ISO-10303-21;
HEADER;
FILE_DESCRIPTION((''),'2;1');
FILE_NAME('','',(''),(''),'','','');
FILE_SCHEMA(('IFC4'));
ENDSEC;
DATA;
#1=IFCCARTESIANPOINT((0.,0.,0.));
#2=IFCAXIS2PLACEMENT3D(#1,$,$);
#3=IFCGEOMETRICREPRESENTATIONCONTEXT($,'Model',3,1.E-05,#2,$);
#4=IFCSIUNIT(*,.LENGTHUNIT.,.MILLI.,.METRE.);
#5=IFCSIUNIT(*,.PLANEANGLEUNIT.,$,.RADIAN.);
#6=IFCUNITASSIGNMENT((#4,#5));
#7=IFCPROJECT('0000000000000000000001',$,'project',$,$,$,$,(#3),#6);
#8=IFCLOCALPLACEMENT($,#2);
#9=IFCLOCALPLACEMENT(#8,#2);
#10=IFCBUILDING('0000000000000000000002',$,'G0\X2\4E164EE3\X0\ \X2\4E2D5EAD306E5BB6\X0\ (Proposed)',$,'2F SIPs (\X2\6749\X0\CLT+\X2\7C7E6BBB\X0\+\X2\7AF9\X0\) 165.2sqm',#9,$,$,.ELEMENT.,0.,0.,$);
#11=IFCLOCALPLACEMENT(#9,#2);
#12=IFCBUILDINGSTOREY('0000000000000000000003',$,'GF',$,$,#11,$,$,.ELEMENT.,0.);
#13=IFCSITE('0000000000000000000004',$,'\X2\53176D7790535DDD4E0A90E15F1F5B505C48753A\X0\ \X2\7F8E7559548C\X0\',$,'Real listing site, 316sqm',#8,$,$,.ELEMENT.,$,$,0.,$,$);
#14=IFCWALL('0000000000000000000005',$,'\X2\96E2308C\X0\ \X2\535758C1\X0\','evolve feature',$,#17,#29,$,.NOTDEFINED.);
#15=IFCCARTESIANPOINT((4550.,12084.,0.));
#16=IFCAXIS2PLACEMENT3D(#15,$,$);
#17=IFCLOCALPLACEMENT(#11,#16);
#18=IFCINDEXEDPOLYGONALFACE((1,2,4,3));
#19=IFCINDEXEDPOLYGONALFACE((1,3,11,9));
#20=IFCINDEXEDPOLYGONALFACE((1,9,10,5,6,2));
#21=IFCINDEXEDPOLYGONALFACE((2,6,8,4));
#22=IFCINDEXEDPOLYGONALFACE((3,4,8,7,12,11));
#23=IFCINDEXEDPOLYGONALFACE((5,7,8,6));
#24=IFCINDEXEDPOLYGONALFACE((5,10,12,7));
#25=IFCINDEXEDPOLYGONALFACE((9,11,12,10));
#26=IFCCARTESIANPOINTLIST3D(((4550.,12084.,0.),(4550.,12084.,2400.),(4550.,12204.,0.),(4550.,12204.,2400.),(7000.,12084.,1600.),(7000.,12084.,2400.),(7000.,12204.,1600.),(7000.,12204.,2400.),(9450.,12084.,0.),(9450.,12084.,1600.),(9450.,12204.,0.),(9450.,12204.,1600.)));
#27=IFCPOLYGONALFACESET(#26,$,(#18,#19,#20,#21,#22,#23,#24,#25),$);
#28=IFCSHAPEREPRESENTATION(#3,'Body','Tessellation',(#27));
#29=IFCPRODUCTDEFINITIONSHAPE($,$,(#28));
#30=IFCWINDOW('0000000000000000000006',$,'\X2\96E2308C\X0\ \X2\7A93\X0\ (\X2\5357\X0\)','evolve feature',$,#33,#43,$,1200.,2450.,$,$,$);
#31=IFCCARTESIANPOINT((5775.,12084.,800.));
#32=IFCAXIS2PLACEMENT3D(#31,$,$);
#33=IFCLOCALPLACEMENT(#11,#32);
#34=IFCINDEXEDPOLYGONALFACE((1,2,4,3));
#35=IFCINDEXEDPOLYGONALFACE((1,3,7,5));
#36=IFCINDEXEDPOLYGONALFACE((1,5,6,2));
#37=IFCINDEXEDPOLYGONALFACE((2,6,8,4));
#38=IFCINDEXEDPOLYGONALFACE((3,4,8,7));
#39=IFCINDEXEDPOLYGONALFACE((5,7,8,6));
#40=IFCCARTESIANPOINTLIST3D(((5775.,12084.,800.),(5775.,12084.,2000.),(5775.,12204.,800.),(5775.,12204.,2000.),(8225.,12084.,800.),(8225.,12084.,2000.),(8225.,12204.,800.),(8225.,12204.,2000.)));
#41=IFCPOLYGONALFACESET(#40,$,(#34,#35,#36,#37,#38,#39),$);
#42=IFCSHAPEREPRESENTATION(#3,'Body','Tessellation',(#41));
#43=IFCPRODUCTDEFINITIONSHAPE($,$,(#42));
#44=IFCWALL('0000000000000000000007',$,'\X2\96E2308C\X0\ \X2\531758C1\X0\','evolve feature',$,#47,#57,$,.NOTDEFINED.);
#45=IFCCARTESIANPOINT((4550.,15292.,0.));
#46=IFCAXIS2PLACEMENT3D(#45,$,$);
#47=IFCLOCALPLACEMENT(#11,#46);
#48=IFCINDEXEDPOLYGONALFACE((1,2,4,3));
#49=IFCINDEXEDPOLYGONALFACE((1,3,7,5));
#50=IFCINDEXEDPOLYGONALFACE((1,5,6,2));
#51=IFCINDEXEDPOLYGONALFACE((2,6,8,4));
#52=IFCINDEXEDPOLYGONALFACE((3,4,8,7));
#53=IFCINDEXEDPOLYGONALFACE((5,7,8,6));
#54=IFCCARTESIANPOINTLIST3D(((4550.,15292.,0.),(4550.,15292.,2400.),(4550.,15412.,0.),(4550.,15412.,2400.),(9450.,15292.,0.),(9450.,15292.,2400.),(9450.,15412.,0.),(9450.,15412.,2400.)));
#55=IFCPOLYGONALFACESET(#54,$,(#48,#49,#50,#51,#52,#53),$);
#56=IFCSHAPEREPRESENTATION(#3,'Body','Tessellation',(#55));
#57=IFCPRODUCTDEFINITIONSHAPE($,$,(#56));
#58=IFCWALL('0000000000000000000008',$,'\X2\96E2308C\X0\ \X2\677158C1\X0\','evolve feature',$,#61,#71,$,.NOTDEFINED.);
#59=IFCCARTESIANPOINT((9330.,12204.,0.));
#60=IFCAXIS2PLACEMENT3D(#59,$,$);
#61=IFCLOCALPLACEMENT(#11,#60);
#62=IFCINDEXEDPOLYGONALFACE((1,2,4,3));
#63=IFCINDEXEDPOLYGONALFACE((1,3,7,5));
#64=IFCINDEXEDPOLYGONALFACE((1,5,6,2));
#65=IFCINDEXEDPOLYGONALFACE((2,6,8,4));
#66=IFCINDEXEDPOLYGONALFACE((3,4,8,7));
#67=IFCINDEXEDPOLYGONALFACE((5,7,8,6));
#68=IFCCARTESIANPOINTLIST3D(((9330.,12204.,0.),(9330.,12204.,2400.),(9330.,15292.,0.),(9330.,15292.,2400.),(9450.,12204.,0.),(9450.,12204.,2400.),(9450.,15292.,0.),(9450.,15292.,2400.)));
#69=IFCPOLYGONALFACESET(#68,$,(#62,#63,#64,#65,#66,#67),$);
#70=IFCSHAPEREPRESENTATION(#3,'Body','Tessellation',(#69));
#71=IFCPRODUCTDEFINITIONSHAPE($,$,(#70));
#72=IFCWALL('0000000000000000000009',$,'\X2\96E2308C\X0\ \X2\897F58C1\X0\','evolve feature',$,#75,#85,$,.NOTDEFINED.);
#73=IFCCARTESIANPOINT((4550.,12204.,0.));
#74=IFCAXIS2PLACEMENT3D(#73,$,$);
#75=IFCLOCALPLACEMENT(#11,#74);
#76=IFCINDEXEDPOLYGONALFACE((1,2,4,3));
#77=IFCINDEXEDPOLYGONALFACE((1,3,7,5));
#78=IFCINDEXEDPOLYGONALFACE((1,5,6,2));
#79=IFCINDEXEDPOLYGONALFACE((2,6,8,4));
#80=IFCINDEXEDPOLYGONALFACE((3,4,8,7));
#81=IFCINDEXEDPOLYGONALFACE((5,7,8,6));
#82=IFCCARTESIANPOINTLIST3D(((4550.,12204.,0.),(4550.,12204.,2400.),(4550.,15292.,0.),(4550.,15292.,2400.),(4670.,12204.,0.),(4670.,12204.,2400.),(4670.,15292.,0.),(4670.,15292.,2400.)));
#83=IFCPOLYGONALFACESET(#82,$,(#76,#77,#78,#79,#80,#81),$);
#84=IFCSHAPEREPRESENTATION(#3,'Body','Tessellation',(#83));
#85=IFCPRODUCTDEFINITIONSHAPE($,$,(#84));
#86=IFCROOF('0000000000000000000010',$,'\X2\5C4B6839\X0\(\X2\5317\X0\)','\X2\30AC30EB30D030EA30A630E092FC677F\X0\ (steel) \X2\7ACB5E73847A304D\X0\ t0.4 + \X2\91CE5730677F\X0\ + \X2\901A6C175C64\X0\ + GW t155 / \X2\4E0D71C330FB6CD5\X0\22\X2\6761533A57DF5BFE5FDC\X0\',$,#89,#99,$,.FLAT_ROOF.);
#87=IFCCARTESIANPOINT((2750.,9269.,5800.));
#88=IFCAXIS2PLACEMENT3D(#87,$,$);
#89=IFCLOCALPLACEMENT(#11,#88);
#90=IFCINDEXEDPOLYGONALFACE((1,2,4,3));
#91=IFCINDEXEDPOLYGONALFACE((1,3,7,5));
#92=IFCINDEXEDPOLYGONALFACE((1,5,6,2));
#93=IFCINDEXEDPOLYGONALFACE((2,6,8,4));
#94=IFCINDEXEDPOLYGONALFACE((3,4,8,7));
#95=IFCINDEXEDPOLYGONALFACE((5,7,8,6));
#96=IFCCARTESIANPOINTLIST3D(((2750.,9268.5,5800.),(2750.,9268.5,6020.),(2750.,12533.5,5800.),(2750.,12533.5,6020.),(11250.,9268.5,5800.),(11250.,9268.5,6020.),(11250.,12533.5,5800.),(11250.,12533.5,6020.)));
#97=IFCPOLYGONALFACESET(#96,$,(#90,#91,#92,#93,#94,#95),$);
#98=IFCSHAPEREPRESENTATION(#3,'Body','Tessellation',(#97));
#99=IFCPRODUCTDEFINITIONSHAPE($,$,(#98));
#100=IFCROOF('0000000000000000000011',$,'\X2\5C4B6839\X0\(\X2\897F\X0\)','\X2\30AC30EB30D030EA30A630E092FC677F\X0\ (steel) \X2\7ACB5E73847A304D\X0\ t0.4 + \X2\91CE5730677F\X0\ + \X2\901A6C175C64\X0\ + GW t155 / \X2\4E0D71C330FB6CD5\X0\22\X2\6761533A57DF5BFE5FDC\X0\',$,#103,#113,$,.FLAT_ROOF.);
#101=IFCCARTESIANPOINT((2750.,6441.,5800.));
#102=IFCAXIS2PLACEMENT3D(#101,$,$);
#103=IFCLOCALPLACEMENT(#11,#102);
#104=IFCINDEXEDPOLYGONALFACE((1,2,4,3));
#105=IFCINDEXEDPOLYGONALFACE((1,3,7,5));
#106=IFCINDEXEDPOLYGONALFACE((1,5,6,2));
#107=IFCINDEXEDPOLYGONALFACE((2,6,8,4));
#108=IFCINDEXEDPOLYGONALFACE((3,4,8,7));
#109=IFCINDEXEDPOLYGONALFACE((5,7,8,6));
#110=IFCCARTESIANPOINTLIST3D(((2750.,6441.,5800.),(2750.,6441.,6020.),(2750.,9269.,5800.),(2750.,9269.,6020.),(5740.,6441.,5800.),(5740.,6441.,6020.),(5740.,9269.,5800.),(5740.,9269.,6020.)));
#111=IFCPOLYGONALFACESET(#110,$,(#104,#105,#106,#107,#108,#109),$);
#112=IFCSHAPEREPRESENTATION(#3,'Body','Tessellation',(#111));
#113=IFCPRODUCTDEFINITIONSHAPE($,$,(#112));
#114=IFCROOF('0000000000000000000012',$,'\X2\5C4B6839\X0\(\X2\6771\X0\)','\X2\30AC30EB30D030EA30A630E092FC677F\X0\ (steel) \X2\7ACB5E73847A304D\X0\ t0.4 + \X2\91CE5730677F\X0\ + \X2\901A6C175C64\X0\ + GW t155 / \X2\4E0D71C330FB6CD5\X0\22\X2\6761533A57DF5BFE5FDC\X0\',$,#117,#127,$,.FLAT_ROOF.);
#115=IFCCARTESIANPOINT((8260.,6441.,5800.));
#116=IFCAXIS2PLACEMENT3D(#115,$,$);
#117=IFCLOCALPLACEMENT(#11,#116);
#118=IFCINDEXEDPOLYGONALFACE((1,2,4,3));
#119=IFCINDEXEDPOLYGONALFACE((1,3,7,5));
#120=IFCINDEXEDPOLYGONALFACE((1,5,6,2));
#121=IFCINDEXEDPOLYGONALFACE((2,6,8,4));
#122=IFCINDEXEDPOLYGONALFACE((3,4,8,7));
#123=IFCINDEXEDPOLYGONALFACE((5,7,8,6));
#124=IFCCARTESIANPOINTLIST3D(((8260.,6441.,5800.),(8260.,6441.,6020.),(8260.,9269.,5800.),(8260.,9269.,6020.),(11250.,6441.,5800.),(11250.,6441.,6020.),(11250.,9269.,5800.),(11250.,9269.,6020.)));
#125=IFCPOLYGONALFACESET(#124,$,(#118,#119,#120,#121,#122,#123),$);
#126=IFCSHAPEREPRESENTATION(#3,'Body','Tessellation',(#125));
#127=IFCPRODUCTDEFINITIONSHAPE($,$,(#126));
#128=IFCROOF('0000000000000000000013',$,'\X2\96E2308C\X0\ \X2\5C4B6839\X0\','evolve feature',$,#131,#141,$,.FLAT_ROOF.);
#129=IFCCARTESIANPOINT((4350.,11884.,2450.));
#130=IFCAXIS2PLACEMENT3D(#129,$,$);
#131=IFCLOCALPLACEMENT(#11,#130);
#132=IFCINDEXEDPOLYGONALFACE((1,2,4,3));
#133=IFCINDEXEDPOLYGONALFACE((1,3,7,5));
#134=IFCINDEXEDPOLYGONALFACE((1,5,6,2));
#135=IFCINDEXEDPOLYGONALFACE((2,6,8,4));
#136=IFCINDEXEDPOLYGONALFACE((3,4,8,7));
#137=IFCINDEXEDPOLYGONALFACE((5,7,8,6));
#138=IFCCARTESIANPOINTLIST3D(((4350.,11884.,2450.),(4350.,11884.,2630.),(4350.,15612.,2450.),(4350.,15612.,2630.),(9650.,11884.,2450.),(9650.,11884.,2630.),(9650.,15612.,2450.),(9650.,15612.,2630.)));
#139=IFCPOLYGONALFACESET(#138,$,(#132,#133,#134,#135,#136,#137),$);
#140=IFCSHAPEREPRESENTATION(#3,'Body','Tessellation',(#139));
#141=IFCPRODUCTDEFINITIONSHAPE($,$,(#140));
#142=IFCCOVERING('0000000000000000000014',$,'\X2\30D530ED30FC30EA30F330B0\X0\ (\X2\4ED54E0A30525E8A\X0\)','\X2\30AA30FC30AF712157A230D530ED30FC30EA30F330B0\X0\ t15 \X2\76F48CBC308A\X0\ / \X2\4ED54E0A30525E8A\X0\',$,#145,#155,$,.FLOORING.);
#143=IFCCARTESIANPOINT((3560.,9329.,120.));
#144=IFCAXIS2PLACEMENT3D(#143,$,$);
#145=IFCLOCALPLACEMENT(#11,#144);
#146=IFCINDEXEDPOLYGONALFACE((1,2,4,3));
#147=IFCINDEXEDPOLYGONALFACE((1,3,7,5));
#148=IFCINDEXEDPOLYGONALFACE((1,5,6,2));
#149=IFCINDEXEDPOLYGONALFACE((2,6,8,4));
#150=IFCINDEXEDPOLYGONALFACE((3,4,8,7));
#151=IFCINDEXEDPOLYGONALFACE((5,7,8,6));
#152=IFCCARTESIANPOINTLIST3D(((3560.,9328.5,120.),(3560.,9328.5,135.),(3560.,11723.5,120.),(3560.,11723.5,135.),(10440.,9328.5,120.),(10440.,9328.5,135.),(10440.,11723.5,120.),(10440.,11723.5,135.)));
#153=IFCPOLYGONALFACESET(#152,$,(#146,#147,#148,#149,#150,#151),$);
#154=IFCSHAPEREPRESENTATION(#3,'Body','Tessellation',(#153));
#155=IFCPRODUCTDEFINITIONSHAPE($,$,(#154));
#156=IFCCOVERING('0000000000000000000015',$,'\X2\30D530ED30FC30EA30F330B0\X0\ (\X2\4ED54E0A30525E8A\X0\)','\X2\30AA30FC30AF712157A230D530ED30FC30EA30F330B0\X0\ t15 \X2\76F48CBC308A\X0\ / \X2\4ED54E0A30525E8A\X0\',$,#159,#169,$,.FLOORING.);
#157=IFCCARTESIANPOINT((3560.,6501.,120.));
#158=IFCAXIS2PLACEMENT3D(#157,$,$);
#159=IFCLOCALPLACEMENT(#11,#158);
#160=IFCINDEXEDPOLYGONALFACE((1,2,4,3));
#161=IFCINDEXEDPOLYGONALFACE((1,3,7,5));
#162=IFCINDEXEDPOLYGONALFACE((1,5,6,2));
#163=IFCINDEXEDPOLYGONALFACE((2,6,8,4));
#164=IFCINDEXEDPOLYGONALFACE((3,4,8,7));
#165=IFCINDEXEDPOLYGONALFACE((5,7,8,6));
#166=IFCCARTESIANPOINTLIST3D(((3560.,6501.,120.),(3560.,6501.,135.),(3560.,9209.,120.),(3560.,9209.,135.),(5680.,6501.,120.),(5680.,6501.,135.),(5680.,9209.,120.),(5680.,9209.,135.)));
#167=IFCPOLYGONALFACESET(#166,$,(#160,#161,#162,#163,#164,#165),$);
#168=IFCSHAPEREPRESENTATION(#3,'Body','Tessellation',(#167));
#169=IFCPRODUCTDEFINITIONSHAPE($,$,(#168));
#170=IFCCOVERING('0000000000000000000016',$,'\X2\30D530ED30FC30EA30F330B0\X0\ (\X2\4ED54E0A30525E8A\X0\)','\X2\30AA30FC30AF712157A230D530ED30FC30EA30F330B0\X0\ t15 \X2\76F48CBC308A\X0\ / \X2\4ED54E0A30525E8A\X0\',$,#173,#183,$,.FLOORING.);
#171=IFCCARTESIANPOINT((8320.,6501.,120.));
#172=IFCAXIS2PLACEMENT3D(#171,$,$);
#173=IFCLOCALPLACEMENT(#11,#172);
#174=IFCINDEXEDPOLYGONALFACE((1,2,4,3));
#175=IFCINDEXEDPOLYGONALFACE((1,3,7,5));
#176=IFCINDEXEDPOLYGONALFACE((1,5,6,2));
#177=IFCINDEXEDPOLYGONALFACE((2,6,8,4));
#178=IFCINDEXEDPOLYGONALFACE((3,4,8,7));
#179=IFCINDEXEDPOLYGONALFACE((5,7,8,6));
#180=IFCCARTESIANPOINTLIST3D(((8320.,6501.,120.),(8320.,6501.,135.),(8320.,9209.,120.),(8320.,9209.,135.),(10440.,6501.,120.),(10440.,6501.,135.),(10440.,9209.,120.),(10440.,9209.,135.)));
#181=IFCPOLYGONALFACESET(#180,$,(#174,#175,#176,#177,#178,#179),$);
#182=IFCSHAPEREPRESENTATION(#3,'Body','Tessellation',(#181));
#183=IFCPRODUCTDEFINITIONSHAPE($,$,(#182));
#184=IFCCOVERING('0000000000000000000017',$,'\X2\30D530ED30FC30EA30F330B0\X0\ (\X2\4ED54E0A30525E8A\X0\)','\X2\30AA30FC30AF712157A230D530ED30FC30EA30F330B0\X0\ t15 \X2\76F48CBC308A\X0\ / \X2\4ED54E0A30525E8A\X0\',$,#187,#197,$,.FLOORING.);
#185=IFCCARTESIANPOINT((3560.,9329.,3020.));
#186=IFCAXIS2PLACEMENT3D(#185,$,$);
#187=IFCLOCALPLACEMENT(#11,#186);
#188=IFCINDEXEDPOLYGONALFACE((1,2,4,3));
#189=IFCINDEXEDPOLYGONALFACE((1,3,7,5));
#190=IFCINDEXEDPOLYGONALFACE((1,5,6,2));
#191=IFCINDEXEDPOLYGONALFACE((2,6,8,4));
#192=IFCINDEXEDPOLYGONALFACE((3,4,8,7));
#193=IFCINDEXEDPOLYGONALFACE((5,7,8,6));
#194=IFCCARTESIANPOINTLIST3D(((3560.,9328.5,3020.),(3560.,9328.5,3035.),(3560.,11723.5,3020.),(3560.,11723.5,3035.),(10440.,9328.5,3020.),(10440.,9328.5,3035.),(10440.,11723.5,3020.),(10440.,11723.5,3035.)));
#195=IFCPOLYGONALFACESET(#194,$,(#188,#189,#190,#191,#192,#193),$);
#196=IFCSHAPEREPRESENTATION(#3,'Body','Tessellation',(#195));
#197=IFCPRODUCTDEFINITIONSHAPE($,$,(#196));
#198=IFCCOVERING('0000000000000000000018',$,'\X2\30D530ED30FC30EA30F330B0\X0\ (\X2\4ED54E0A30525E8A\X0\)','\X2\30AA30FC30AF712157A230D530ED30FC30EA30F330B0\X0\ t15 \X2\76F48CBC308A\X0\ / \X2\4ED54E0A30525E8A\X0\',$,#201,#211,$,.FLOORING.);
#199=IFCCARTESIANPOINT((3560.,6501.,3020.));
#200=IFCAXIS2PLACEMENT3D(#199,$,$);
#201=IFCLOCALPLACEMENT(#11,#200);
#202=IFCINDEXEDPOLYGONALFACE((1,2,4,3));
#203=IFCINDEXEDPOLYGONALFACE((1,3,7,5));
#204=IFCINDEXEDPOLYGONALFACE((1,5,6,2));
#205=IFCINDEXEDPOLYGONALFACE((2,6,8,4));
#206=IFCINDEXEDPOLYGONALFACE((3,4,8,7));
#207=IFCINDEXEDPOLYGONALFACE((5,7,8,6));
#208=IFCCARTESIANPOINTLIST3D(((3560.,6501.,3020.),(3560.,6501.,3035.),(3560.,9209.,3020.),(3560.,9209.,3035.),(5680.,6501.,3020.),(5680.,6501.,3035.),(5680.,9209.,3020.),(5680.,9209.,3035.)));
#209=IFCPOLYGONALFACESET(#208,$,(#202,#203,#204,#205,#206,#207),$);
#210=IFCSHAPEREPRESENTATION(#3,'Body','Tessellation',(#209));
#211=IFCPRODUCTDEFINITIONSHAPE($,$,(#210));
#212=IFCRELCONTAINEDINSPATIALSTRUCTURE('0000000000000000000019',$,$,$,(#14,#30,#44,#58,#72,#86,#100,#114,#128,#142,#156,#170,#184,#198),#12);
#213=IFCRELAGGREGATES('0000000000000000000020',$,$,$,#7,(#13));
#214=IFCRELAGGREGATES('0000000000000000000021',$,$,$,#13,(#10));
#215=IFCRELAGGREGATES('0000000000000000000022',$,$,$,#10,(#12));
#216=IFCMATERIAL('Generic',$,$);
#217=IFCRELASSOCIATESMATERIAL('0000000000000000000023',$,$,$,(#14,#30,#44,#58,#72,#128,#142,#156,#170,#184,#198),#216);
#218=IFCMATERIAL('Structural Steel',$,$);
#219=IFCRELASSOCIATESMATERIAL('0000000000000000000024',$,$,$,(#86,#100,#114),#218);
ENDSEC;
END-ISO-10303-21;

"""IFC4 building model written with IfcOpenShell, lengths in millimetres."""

from ifc_helpers import new_model, si_unit, frame, frame_2d, origin, place, context, project, spatial, rectangle, extrude, material, element, fill, save


model = new_model("IFC4")

# Units and contexts
model_context = context("Model", 3, precision=1e-05, world=origin())
ifc_project = project(units=[si_unit("LENGTHUNIT", "METRE", prefix="MILLI"), si_unit("PLANEANGLEUNIT", "RADIAN")], contexts=[model_context])

# Site, building, storey
site_placement = place(None, origin())
site = spatial("IfcSite", under=ifc_project, at=site_placement, Name="北海道川上郡弟子屈町 美留和", ObjectType="Real listing site, 316sqm", CompositionType="ELEMENT", RefElevation=0.0)
building_placement = place(site_placement, origin())
building = spatial("IfcBuilding", under=site, at=building_placement, Name="G0世代 中庭の家 (Proposed)", ObjectType="2F SIPs (杉CLT+籾殻+竹) 165.2sqm", CompositionType="ELEMENT", ElevationOfRefHeight=0.0, ElevationOfTerrain=0.0)
storey_placement = place(building_placement, origin())
storey = spatial("IfcBuildingStorey", under=building, at=storey_placement, Name="GF", CompositionType="ELEMENT", Elevation=0.0)

# Shared definitions
ifc_material_1 = material(Name="Generic")

# Wall, opening, window
wall_1_placement = place(storey_placement, frame((4550.0, 12084.0, 0.0)))
wall_1 = element("IfcWall", 1, at=wall_1_placement, inside=storey, material=ifc_material_1, Name="離れ 南壁", Description="evolve feature", PredefinedType="NOTDEFINED", context=model_context, shape_type="SweptSolid", body=[
    extrude(rectangle(XDim=4900.0, YDim=120.0, at=frame_2d((2450.0, 60.0))), frame((4550.0, 12084.0, 0.0)), (0.0, 0.0, 1.0), 2400.0),
])
opening_1_placement = place(storey_placement, frame((5775.0, 12084.0, 800.0)))
opening_1 = element("IfcOpeningElement", 2, at=opening_1_placement, cuts=wall_1, PredefinedType="NOTDEFINED", context=model_context, shape_type="SweptSolid", body=[
    extrude(rectangle(XDim=2450.0, YDim=120.0, at=frame_2d((1225.0, 60.0))), frame((5775.0, 12084.0, 800.0)), (0.0, 0.0, 1.0), 1200.0),
])
window_1_placement = place(storey_placement, frame((5775.0, 12084.0, 800.0)))
window_1 = element("IfcWindow", 3, at=window_1_placement, inside=storey, material=ifc_material_1, Name="離れ 窓 (南)", Description="evolve feature", OverallHeight=1200.0, OverallWidth=2450.0, context=model_context, shape_type="SweptSolid", body=[
    extrude(rectangle(XDim=2450.0, YDim=120.0, at=frame_2d((1225.0, 60.0))), frame((5775.0, 12084.0, 800.0)), (0.0, 0.0, 1.0), 1200.0),
])
fill(opening_1, window_1)

# Walls
wall_2_placement = place(storey_placement, frame((4550.0, 15292.0, 0.0)))
element("IfcWall", 4, at=wall_2_placement, inside=storey, material=ifc_material_1, Name="離れ 北壁", Description="evolve feature", PredefinedType="NOTDEFINED", context=model_context, shape_type="SweptSolid", body=[
    extrude(rectangle(XDim=4900.0, YDim=120.0, at=frame_2d((2450.0, 60.0))), frame((4550.0, 15292.0, 0.0)), (0.0, 0.0, 1.0), 2400.0),
])
wall_3_placement = place(storey_placement, frame((9330.0, 12204.0, 0.0)))
element("IfcWall", 5, at=wall_3_placement, inside=storey, material=ifc_material_1, Name="離れ 東壁", Description="evolve feature", PredefinedType="NOTDEFINED", context=model_context, shape_type="SweptSolid", body=[
    extrude(rectangle(XDim=120.0, YDim=3088.0, at=frame_2d((60.0, 1544.0))), frame((9330.0, 12204.0, 0.0)), (0.0, 0.0, 1.0), 2400.0),
])
wall_4_placement = place(storey_placement, frame((4550.0, 12204.0, 0.0)))
element("IfcWall", 6, at=wall_4_placement, inside=storey, material=ifc_material_1, Name="離れ 西壁", Description="evolve feature", PredefinedType="NOTDEFINED", context=model_context, shape_type="SweptSolid", body=[
    extrude(rectangle(XDim=120.0, YDim=3088.0, at=frame_2d((60.0, 1544.0))), frame((4550.0, 12204.0, 0.0)), (0.0, 0.0, 1.0), 2400.0),
])

# Roofs
ifc_material_2 = material(Name="Structural Steel")
for number, where, name in (
    (7, (2750.0, 9269.0, 5800.0), "屋根(北)"),
):
    element("IfcRoof", number, at=place(storey_placement, frame(where)), inside=storey, material=ifc_material_2, Name=name, Description="ガルバリウム鋼板 (steel) 立平葺き t0.4 + 野地板 + 通気層 + GW t155 / 不燃・法22条区域対応", PredefinedType="FLAT_ROOF", context=model_context, shape_type="SweptSolid", body=[
        extrude(rectangle(XDim=8500.0, YDim=3265.0, at=frame_2d((4250.0, 1632.0))), frame((2750.0, 9269.0, 5800.0)), (0.0, 0.0, 1.0), 220.0),
    ])
roof_1_placement = place(storey_placement, frame((2750.0, 6441.0, 5800.0)))
element("IfcRoof", 8, at=roof_1_placement, inside=storey, material=ifc_material_2, Name="屋根(西)", Description="ガルバリウム鋼板 (steel) 立平葺き t0.4 + 野地板 + 通気層 + GW t155 / 不燃・法22条区域対応", PredefinedType="FLAT_ROOF", context=model_context, shape_type="SweptSolid", body=[
    extrude(rectangle(XDim=2990.0, YDim=2828.0, at=frame_2d((1495.0, 1414.0))), frame((2750.0, 6441.0, 5800.0)), (0.0, 0.0, 1.0), 220.0),
])
roof_2_placement = place(storey_placement, frame((8260.0, 6441.0, 5800.0)))
element("IfcRoof", 9, at=roof_2_placement, inside=storey, material=ifc_material_2, Name="屋根(東)", Description="ガルバリウム鋼板 (steel) 立平葺き t0.4 + 野地板 + 通気層 + GW t155 / 不燃・法22条区域対応", PredefinedType="FLAT_ROOF", context=model_context, shape_type="SweptSolid", body=[
    extrude(rectangle(XDim=2990.0, YDim=2828.0, at=frame_2d((1495.0, 1414.0))), frame((8260.0, 6441.0, 5800.0)), (0.0, 0.0, 1.0), 220.0),
])
roof_3_placement = place(storey_placement, frame((4350.0, 11884.0, 2450.0)))
element("IfcRoof", 10, at=roof_3_placement, inside=storey, material=ifc_material_1, Name="離れ 屋根", Description="evolve feature", PredefinedType="FLAT_ROOF", context=model_context, shape_type="SweptSolid", body=[
    extrude(rectangle(XDim=5300.0, YDim=3728.0, at=frame_2d((2650.0, 1864.0))), frame((4350.0, 11884.0, 2450.0)), (0.0, 0.0, 1.0), 180.0),
])

# Coverings
covering_1_placement = place(storey_placement, frame((3560.0, 9329.0, 120.0)))
element("IfcCovering", 11, at=covering_1_placement, inside=storey, material=ifc_material_1, Name="フローリング (仕上げ床)", Description="オーク無垢フローリング t15 直貼り / 仕上げ床", PredefinedType="FLOORING", context=model_context, shape_type="SweptSolid", body=[
    extrude(rectangle(XDim=6880.0, YDim=2395.0, at=frame_2d((3440.0, 1197.0))), frame((3560.0, 9329.0, 120.0)), (0.0, 0.0, 1.0), 15.0),
])
covering_2_placement = place(storey_placement, frame((3560.0, 6501.0, 120.0)))
element("IfcCovering", 12, at=covering_2_placement, inside=storey, material=ifc_material_1, Name="フローリング (仕上げ床)", Description="オーク無垢フローリング t15 直貼り / 仕上げ床", PredefinedType="FLOORING", context=model_context, shape_type="SweptSolid", body=[
    extrude(rectangle(XDim=2120.0, YDim=2708.0, at=frame_2d((1060.0, 1354.0))), frame((3560.0, 6501.0, 120.0)), (0.0, 0.0, 1.0), 15.0),
])
covering_3_placement = place(storey_placement, frame((8320.0, 6501.0, 120.0)))
element("IfcCovering", 13, at=covering_3_placement, inside=storey, material=ifc_material_1, Name="フローリング (仕上げ床)", Description="オーク無垢フローリング t15 直貼り / 仕上げ床", PredefinedType="FLOORING", context=model_context, shape_type="SweptSolid", body=[
    extrude(rectangle(XDim=2120.0, YDim=2708.0, at=frame_2d((1060.0, 1354.0))), frame((8320.0, 6501.0, 120.0)), (0.0, 0.0, 1.0), 15.0),
])
covering_4_placement = place(storey_placement, frame((3560.0, 9329.0, 3020.0)))
element("IfcCovering", 14, at=covering_4_placement, inside=storey, material=ifc_material_1, Name="フローリング (仕上げ床)", Description="オーク無垢フローリング t15 直貼り / 仕上げ床", PredefinedType="FLOORING", context=model_context, shape_type="SweptSolid", body=[
    extrude(rectangle(XDim=6880.0, YDim=2395.0, at=frame_2d((3440.0, 1197.0))), frame((3560.0, 9329.0, 3020.0)), (0.0, 0.0, 1.0), 15.0),
])
covering_5_placement = place(storey_placement, frame((3560.0, 6501.0, 3020.0)))
element("IfcCovering", 15, at=covering_5_placement, inside=storey, material=ifc_material_1, Name="フローリング (仕上げ床)", Description="オーク無垢フローリング t15 直貼り / 仕上げ床", PredefinedType="FLOORING", context=model_context, shape_type="SweptSolid", body=[
    extrude(rectangle(XDim=2120.0, YDim=2708.0, at=frame_2d((1060.0, 1354.0))), frame((3560.0, 6501.0, 3020.0)), (0.0, 0.0, 1.0), 15.0),
])

save(model, "model.ifc")
